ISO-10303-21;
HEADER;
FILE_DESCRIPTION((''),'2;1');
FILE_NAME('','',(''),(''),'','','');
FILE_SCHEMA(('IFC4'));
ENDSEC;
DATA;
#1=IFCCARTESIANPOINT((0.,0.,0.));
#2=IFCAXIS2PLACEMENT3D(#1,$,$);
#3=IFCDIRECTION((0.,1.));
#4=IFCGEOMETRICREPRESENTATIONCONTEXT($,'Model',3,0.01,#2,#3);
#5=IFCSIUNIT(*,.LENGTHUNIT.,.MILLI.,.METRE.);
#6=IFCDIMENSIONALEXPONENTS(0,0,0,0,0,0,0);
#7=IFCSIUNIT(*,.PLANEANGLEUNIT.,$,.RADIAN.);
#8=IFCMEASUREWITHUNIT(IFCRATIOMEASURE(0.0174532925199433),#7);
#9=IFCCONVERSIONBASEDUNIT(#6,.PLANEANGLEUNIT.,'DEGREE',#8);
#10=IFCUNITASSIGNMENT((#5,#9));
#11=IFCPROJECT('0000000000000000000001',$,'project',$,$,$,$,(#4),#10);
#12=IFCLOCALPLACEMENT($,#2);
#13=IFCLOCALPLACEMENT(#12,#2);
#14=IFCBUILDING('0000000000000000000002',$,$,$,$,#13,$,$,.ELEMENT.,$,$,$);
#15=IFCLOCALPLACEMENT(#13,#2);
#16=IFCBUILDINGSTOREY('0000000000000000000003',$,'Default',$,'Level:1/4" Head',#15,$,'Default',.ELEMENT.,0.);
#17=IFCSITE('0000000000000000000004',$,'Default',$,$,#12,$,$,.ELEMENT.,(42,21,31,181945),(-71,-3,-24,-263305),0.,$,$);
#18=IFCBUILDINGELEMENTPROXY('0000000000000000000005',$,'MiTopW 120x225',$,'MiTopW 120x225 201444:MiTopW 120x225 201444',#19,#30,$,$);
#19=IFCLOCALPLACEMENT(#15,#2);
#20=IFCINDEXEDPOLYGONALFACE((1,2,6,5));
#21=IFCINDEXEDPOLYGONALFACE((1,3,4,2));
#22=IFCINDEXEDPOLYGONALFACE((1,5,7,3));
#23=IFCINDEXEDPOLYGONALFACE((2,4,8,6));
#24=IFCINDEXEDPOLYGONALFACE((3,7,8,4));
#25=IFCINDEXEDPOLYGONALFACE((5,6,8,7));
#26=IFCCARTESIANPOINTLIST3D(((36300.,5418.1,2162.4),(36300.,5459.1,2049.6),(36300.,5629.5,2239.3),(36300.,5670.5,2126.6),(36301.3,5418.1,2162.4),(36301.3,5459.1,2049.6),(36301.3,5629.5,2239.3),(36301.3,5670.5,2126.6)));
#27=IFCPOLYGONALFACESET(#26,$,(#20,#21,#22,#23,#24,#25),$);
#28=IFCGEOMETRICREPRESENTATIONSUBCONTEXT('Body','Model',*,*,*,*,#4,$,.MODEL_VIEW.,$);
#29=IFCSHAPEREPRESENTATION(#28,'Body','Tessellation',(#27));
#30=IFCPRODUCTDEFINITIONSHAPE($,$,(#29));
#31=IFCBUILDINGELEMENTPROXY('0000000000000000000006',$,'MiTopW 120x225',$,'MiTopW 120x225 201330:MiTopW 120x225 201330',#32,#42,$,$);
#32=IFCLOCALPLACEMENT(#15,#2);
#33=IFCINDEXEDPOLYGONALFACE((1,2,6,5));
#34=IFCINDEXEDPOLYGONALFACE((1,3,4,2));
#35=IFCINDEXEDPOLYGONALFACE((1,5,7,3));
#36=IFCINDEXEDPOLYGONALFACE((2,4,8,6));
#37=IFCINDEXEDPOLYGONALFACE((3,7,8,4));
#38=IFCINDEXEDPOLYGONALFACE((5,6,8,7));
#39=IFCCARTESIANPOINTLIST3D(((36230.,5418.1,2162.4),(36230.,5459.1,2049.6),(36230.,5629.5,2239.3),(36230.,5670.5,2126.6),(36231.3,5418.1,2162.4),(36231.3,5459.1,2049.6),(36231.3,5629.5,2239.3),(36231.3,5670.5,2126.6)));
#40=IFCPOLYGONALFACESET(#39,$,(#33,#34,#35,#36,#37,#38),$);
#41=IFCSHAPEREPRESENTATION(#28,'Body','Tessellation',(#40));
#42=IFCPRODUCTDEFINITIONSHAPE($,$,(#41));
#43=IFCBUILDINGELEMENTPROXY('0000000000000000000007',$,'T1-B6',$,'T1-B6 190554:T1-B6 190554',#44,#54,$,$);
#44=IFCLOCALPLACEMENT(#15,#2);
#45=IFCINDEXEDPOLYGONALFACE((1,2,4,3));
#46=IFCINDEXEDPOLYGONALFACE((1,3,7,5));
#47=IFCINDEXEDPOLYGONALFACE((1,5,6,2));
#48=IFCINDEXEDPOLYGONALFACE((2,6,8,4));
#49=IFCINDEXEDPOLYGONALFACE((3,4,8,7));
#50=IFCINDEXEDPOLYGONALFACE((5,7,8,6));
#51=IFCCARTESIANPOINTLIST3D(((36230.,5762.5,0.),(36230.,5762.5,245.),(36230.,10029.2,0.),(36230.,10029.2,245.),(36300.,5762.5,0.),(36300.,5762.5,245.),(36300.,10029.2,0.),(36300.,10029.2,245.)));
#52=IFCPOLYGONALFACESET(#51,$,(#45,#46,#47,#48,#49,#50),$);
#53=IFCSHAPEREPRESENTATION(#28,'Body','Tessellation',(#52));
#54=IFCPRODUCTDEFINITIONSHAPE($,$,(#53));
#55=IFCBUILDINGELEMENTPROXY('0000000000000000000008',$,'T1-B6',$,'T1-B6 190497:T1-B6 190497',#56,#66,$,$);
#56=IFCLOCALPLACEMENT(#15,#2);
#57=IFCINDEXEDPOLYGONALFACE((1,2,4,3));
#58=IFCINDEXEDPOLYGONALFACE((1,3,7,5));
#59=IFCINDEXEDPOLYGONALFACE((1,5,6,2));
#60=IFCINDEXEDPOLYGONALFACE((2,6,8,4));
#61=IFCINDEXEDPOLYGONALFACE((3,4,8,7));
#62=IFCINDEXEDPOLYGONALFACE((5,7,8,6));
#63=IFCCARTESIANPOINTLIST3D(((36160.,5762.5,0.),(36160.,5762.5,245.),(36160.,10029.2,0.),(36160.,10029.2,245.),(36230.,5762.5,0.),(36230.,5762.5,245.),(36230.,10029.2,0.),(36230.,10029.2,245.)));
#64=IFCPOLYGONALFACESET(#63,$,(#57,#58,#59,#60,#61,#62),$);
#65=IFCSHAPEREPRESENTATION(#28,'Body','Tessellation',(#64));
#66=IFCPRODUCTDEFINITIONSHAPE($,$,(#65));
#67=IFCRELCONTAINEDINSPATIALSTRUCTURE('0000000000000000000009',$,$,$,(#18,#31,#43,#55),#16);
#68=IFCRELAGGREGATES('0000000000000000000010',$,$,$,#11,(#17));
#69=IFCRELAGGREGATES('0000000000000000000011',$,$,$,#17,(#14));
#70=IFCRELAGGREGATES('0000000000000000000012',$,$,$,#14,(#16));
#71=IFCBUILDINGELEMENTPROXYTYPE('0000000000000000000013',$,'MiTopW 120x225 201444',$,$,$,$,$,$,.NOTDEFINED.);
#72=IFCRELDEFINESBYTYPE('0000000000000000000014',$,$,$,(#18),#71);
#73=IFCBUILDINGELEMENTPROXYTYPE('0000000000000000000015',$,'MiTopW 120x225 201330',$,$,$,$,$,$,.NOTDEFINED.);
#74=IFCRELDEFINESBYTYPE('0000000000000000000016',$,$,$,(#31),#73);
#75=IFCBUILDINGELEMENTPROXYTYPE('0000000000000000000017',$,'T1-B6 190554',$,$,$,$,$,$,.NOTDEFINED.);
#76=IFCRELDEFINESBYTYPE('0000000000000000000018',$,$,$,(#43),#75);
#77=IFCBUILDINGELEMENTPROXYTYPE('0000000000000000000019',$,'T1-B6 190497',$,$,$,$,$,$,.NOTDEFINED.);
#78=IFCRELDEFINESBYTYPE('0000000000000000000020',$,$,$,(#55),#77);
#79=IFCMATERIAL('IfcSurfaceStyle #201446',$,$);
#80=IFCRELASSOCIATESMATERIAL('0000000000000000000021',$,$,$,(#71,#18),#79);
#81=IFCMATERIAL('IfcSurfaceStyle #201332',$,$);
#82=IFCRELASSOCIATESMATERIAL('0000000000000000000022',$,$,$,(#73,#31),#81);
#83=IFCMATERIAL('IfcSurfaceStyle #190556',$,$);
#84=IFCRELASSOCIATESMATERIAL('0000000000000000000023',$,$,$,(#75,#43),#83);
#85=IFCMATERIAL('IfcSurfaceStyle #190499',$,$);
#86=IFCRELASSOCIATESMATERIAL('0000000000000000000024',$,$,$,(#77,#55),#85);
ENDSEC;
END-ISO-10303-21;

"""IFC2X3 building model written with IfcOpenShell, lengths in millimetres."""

from ifc_helpers import new_model, entity, si_unit, converted_unit, direction, frame, origin, origin_2d_with_axis, place, context, subcontext, project, spatial, polyline, rectangle, outline, extrude, source, transform, mapped, material, type_object, type_shapes, element, save


model = new_model("IFC2X3")

# Units and contexts
model_context = context("Model", 3, precision=0.01, world=origin(), true_north=direction((0.0, 1.0)))
body_context = subcontext(model_context, "Body", "Model", "MODEL_VIEW")
ifc_project = project(units=[si_unit("LENGTHUNIT", "METRE", prefix="MILLI"), converted_unit("PLANEANGLEUNIT", "DEGREE", entity("IfcRatioMeasure", 0.0174532925199433), si_unit("PLANEANGLEUNIT", "RADIAN"), dimensions=[0, 0, 0, 0, 0, 0, 0])], contexts=[model_context])

# Site, building, storey
site_placement = place(None, origin())
site = spatial("IfcSite", under=ifc_project, at=site_placement, Name="Default", CompositionType="ELEMENT", RefLatitude=(42, 21, 31, 181945), RefLongitude=(-71, -3, -24, -263305), RefElevation=0.0)
building_placement = place(site_placement, origin())
building = spatial("IfcBuilding", under=site, at=building_placement, CompositionType="ELEMENT")
storey_placement = place(building_placement, origin())
storey = spatial("IfcBuildingStorey", under=building, at=storey_placement, Name="Default", ObjectType="Level:1/4\" Head", LongName="Default", CompositionType="ELEMENT", Elevation=0.0)

# Building element proxies
ifc_material_1 = material(Name="IfcSurfaceStyle #201446")
building_element_proxy_type_1 = type_object("IfcBuildingElementProxyType", Name="MiTopW 120x225 201444", PredefinedType="NOTDEFINED", material=ifc_material_1)
shared_shape_1 = source(origin(), body_context, "Body", "SweptSolid", [
    extrude(outline(polyline([(-112.5, -60.0), (112.5, -60.0), (112.5, 60.0), (-112.5, 60.0), (-112.5, -60.0)])), frame((112.5, 60.0, 0.0), z_axis=(0.0, 0.0, 1.0), x_axis=(-1.0, 0.0, 0.0)), (0.0, 0.0, 1.0), 1.3),
])
type_shapes(building_element_proxy_type_1, [shared_shape_1])
proxy_1_placement = place(building_placement, frame((36301.3, 5418.1, 2162.4), z_axis=(-1.0, 0.0, 0.0), x_axis=(0.0, 0.939693, 0.34202)))
element("IfcBuildingElementProxy", 1, at=proxy_1_placement, inside=storey, type_object=building_element_proxy_type_1, material=ifc_material_1, Name="MiTopW 120x225", ObjectType="MiTopW 120x225 201444:MiTopW 120x225 201444", context=body_context, shape_type="MappedRepresentation", body=[
    mapped(shared_shape_1, transform((0.0, 0.0, 0.0), scale=1.0)),
])
ifc_material_2 = material(Name="IfcSurfaceStyle #201332")
building_element_proxy_type_2 = type_object("IfcBuildingElementProxyType", Name="MiTopW 120x225 201330", PredefinedType="NOTDEFINED", material=ifc_material_2)
shared_shape_2 = source(origin(), body_context, "Body", "SweptSolid", [
    extrude(outline(polyline([(-112.5, -60.0), (112.5, -60.0), (112.5, 60.0), (-112.5, 60.0), (-112.5, -60.0)])), frame((112.5, 60.0, 0.0), z_axis=(0.0, 0.0, 1.0), x_axis=(-1.0, 0.0, 0.0)), (0.0, 0.0, 1.0), 1.3),
])
type_shapes(building_element_proxy_type_2, [shared_shape_2])
proxy_2_placement = place(building_placement, frame((36231.3, 5418.1, 2162.4), z_axis=(-1.0, 0.0, 0.0), x_axis=(0.0, 0.939693, 0.34202)))
element("IfcBuildingElementProxy", 2, at=proxy_2_placement, inside=storey, type_object=building_element_proxy_type_2, material=ifc_material_2, Name="MiTopW 120x225", ObjectType="MiTopW 120x225 201330:MiTopW 120x225 201330", context=body_context, shape_type="MappedRepresentation", body=[
    mapped(shared_shape_2, transform((0.0, 0.0, 0.0), scale=1.0)),
])
ifc_material_3 = material(Name="IfcSurfaceStyle #190556")
building_element_proxy_type_3 = type_object("IfcBuildingElementProxyType", Name="T1-B6 190554", PredefinedType="NOTDEFINED", material=ifc_material_3)
shared_shape_3 = source(origin(), body_context, "Body", "SweptSolid", [
    extrude(rectangle(XDim=4266.8, YDim=245.0, at=origin_2d_with_axis()), frame((2133.4, 122.5, 0.0), z_axis=(0.0, 0.0, 1.0), x_axis=(-1.0, 0.0, 0.0)), (0.0, 0.0, 1.0), 70.0),
])
type_shapes(building_element_proxy_type_3, [shared_shape_3])
proxy_3_placement = place(building_placement, frame((36300.0, 5762.5, 245.0), z_axis=(-1.0, 0.0, 0.0), x_axis=(0.0, 1.0, 0.0)))
element("IfcBuildingElementProxy", 3, at=proxy_3_placement, inside=storey, type_object=building_element_proxy_type_3, material=ifc_material_3, Name="T1-B6", ObjectType="T1-B6 190554:T1-B6 190554", context=body_context, shape_type="MappedRepresentation", body=[
    mapped(shared_shape_3, transform((0.0, 0.0, 0.0), scale=1.0)),
])
ifc_material_4 = material(Name="IfcSurfaceStyle #190499")
building_element_proxy_type_4 = type_object("IfcBuildingElementProxyType", Name="T1-B6 190497", PredefinedType="NOTDEFINED", material=ifc_material_4)
shared_shape_4 = source(origin(), body_context, "Body", "SweptSolid", [
    extrude(rectangle(XDim=4266.8, YDim=245.0, at=origin_2d_with_axis()), frame((2133.4, 122.5, 0.0), z_axis=(0.0, 0.0, 1.0), x_axis=(-1.0, 0.0, 0.0)), (0.0, 0.0, 1.0), 70.0),
])
type_shapes(building_element_proxy_type_4, [shared_shape_4])
proxy_4_placement = place(building_placement, frame((36230.0, 5762.5, 245.0), z_axis=(-1.0, 0.0, 0.0), x_axis=(0.0, 1.0, 0.0)))
element("IfcBuildingElementProxy", 4, at=proxy_4_placement, inside=storey, type_object=building_element_proxy_type_4, material=ifc_material_4, Name="T1-B6", ObjectType="T1-B6 190497:T1-B6 190497", context=body_context, shape_type="MappedRepresentation", body=[
    mapped(shared_shape_4, transform((0.0, 0.0, 0.0), scale=1.0)),
])

save(model, "model.ifc")
